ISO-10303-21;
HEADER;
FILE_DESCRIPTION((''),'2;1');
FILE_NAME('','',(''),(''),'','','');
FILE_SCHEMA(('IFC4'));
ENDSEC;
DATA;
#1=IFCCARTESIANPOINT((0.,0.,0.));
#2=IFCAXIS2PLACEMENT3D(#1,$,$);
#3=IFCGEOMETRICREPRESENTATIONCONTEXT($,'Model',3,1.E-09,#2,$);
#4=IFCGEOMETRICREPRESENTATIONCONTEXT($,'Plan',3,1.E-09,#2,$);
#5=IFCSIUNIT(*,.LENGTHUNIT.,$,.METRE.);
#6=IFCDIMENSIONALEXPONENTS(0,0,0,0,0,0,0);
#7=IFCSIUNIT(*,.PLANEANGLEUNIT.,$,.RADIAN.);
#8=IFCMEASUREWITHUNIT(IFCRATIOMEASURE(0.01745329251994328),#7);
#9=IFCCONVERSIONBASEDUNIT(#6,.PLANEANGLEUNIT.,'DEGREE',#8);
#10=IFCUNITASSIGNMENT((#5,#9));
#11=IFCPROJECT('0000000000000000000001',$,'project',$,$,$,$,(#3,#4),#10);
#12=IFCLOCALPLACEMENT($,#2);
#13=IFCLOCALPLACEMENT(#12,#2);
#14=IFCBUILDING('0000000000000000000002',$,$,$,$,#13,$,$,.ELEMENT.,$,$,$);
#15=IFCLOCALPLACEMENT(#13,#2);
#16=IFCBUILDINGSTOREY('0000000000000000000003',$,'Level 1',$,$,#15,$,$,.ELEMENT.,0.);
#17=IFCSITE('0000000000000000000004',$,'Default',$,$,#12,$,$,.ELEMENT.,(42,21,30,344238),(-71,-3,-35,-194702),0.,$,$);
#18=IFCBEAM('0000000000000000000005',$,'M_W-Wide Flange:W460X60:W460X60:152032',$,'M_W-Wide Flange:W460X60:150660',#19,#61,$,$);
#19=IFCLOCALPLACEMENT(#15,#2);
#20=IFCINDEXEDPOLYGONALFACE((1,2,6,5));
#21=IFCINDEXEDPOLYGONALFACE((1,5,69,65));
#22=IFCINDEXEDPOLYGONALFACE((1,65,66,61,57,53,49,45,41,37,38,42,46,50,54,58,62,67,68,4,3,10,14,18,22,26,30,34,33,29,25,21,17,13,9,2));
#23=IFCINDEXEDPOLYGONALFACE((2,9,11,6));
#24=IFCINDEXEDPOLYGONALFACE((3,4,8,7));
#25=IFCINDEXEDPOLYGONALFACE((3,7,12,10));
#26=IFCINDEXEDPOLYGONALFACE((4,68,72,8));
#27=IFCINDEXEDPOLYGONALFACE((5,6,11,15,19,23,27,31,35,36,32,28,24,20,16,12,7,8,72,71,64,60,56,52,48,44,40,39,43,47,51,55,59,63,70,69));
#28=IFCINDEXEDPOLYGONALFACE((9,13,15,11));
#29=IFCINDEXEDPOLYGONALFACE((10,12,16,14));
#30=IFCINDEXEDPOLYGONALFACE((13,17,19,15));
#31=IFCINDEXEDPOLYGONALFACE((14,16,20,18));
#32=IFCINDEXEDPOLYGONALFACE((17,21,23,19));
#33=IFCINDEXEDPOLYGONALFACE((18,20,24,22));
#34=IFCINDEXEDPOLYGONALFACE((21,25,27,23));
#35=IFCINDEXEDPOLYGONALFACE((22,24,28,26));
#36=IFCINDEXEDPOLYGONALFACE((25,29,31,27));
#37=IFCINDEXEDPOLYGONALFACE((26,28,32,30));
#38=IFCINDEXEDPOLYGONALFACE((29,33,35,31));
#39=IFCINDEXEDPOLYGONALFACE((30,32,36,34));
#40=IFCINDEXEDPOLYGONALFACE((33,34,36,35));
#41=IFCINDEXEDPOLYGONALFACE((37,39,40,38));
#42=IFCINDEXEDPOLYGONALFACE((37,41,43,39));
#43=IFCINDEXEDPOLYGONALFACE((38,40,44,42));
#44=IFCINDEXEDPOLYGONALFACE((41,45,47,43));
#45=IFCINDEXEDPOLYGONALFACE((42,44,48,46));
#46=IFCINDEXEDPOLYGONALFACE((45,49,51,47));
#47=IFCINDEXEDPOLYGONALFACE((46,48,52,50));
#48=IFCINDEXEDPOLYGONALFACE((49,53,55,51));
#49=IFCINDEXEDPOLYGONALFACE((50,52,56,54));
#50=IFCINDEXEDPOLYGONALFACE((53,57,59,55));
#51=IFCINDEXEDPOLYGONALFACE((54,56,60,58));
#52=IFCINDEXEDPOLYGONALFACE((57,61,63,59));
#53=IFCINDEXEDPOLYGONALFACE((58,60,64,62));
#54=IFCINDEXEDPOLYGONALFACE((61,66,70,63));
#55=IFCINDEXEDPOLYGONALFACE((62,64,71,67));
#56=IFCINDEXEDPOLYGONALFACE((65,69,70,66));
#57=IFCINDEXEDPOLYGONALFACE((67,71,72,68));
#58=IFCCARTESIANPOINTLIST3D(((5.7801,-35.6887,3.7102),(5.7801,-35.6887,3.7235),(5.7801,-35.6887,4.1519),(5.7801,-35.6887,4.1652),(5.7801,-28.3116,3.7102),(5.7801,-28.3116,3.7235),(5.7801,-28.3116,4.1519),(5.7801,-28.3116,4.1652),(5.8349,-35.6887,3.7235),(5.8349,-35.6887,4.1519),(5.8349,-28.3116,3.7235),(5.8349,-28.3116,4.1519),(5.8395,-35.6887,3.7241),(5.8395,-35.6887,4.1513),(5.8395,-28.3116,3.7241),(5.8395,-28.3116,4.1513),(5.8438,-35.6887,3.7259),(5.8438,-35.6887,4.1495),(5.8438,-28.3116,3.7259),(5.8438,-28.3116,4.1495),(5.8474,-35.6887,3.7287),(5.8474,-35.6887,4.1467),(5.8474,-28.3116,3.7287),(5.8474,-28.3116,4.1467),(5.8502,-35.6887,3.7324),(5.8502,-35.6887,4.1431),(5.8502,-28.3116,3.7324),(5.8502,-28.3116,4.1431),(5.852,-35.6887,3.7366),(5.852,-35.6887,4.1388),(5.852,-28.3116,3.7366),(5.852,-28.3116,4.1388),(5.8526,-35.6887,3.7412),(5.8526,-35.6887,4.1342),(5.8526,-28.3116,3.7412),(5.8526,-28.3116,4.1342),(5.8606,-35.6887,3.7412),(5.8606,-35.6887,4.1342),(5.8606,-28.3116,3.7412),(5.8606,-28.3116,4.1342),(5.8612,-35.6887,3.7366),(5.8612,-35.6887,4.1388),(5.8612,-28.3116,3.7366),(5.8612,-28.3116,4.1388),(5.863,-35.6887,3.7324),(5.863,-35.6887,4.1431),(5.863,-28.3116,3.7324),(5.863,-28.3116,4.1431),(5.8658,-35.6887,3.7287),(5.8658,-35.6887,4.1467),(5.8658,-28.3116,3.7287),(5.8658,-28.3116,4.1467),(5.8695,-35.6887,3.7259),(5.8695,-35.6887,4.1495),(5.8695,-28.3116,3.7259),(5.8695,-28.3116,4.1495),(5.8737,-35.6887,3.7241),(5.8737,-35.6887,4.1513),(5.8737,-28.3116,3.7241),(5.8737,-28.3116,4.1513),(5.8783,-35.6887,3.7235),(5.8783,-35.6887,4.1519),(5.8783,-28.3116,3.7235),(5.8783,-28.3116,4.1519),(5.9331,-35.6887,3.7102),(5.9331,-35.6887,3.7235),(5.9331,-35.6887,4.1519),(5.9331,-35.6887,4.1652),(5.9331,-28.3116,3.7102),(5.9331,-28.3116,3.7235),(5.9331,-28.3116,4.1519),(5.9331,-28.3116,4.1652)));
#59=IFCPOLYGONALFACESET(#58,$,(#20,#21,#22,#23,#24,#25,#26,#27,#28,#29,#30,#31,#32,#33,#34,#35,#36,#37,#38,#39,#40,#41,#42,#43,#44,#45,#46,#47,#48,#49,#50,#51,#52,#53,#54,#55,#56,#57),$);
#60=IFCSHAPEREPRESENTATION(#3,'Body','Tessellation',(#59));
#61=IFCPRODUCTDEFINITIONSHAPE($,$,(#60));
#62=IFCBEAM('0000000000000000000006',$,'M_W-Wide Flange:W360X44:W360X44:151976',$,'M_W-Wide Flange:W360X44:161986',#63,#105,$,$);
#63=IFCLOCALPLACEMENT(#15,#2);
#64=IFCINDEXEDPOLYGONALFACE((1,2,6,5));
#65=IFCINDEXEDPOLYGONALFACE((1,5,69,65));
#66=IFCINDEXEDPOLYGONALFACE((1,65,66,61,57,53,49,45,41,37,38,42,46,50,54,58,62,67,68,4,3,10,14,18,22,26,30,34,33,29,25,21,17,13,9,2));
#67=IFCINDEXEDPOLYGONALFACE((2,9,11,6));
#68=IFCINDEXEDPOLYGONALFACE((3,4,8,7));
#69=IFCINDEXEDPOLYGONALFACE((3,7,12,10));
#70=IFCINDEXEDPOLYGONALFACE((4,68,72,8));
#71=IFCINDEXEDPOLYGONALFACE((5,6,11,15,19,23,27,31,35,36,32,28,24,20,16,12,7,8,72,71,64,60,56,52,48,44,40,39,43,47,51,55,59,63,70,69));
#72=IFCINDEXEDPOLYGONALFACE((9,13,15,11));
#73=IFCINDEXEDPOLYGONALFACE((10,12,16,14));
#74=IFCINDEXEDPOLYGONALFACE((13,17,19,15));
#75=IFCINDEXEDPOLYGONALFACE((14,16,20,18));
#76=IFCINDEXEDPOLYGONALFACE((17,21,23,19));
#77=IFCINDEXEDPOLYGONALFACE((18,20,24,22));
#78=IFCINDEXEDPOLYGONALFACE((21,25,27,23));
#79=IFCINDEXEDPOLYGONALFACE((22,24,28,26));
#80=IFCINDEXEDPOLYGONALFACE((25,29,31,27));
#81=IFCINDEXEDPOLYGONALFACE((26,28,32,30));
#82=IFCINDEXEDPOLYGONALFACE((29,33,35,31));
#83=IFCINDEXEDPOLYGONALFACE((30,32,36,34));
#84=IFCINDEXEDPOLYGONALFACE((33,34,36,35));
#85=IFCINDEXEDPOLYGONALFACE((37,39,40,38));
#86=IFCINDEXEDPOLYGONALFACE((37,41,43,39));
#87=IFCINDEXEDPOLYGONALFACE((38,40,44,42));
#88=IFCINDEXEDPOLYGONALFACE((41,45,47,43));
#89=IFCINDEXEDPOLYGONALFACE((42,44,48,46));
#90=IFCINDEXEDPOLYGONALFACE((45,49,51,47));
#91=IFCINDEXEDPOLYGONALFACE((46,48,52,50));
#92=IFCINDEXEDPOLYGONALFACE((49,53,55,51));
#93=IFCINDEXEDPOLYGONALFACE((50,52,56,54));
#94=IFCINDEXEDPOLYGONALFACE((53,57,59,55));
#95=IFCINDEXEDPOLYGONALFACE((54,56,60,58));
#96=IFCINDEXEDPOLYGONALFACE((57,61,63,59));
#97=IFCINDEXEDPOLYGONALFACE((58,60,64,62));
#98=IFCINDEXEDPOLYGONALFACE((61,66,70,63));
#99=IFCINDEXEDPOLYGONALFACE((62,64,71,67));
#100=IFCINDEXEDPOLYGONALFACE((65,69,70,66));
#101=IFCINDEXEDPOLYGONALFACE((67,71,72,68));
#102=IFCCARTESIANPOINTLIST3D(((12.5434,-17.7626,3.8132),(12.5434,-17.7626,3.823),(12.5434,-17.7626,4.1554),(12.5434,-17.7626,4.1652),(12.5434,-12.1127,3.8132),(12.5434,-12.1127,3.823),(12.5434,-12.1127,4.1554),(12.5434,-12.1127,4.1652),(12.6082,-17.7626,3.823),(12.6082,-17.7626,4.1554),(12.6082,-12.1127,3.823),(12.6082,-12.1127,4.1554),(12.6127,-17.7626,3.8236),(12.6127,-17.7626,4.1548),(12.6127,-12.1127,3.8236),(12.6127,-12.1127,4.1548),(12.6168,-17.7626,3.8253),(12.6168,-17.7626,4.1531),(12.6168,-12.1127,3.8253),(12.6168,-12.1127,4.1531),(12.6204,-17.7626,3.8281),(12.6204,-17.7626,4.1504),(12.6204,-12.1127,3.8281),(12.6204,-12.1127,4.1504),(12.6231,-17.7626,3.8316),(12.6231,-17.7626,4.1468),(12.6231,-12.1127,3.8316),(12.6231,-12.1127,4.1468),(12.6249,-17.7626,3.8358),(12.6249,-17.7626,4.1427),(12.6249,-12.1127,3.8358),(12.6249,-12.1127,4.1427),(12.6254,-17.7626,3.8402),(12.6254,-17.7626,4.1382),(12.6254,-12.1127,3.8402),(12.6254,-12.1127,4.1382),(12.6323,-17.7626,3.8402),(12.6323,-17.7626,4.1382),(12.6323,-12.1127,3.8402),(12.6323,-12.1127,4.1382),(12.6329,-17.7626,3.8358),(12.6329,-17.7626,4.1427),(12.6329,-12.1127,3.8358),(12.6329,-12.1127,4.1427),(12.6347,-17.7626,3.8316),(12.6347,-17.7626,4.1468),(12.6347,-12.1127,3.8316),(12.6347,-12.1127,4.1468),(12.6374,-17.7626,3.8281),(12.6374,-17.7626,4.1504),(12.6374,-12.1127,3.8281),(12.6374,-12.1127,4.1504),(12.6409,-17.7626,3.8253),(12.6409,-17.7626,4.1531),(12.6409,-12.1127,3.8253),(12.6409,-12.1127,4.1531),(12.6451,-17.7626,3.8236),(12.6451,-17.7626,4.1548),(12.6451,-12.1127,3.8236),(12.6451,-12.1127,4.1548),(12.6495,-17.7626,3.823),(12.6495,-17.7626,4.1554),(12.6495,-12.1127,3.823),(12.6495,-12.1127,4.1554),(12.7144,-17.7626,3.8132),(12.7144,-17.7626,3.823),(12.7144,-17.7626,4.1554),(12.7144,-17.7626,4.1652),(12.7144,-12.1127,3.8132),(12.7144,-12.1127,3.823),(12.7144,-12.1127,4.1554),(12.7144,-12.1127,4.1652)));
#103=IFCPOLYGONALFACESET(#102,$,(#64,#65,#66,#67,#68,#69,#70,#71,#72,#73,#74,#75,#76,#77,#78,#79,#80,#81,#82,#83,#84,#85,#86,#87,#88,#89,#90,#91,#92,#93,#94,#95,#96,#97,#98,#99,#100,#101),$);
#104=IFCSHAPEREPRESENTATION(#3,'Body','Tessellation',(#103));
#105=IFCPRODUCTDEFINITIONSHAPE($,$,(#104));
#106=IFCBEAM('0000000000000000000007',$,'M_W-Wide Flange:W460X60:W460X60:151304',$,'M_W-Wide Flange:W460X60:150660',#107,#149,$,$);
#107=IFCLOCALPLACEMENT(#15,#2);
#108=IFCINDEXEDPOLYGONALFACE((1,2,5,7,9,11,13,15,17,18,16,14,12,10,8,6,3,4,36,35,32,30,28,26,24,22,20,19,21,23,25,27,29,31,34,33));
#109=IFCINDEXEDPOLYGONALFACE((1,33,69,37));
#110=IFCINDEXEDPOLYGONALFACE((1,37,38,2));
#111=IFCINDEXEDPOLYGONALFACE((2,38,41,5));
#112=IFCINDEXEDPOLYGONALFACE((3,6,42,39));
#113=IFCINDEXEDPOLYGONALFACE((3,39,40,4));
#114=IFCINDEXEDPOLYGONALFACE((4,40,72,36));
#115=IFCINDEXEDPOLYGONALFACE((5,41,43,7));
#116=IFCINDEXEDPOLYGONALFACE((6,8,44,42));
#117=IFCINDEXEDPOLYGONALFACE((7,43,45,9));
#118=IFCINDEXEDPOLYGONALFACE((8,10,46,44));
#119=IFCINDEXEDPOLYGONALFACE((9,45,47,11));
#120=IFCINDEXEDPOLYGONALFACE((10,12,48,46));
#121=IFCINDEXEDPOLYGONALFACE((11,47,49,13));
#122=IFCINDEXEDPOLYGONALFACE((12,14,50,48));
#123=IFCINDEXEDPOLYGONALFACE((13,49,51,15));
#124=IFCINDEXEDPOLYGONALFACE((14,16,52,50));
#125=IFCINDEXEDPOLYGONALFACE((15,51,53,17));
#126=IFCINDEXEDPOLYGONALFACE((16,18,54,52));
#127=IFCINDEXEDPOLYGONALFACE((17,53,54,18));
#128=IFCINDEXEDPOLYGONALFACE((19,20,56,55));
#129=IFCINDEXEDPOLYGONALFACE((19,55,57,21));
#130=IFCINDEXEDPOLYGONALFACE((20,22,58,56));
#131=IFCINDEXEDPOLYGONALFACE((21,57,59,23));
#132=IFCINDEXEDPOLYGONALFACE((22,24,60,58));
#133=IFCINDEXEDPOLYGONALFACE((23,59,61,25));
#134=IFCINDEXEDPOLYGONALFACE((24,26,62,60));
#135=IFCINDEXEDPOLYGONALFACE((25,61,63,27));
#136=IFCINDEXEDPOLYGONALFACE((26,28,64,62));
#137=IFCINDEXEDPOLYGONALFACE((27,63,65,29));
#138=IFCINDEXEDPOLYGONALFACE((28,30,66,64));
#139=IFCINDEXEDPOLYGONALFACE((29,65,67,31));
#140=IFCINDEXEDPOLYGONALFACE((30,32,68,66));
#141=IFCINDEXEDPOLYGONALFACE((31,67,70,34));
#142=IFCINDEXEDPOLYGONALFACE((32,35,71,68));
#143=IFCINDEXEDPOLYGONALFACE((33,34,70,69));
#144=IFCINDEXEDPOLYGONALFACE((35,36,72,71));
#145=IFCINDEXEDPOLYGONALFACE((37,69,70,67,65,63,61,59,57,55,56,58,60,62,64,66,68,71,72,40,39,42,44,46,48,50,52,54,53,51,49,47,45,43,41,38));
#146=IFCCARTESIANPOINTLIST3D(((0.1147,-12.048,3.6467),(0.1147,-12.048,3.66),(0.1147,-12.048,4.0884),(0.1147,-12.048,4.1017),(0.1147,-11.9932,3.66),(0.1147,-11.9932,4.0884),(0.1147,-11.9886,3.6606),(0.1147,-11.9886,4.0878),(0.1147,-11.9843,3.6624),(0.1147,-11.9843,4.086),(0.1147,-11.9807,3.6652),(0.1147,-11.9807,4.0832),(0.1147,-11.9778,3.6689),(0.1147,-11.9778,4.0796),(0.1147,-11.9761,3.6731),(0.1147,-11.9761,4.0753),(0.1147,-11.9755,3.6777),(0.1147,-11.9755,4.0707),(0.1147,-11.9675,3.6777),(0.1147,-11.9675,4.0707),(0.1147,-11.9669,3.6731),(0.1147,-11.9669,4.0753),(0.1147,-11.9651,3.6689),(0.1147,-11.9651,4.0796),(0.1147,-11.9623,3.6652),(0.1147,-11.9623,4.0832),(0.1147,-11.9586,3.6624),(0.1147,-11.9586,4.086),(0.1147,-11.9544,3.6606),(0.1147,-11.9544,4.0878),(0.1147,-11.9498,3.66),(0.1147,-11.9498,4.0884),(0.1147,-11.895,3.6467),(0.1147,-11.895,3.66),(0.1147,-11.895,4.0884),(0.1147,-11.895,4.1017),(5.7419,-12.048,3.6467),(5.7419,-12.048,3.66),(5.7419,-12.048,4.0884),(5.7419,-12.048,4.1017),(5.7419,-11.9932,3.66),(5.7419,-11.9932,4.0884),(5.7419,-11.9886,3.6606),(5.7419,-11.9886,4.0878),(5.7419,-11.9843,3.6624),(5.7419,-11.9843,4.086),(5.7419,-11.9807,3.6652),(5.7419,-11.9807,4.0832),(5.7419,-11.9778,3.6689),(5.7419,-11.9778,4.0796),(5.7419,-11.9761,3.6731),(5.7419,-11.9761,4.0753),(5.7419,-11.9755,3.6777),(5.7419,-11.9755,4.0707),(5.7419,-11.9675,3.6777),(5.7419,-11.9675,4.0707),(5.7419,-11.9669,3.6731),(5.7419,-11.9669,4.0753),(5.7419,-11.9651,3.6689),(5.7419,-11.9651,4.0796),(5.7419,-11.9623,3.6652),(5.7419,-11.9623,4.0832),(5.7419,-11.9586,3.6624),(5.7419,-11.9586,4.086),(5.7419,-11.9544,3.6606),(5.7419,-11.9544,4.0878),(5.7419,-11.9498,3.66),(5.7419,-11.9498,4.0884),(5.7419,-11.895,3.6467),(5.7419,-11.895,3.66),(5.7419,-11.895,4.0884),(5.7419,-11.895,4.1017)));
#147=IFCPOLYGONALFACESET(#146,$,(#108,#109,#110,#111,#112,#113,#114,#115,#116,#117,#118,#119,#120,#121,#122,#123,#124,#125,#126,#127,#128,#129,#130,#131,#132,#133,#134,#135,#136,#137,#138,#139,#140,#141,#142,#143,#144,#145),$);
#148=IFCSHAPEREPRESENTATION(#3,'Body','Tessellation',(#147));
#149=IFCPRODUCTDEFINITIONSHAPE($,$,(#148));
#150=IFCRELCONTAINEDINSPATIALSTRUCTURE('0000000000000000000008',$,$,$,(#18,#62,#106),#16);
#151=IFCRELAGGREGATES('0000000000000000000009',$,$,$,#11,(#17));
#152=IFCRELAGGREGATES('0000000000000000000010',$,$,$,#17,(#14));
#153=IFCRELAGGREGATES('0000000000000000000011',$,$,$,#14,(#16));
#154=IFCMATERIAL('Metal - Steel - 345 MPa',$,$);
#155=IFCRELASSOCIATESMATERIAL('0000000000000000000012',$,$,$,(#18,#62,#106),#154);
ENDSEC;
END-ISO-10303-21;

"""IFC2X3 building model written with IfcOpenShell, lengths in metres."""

from ifc_helpers import new_model, entity, si_unit, converted_unit, frame, frame_2d, origin, place, context, project, spatial, polyline, circle_curve, parameter, trimmed, segment, composite_curve, outline, extrude, material, element, save


model = new_model("IFC2X3")

# Units and contexts
model_context = context("Model", 3, precision=1e-09, world=origin())
plan_context = context("Plan", 3, precision=1e-09, world=origin())
ifc_project = project(units=[si_unit("LENGTHUNIT", "METRE"), converted_unit("PLANEANGLEUNIT", "DEGREE", entity("IfcRatioMeasure", 0.01745329251994328), si_unit("PLANEANGLEUNIT", "RADIAN"), dimensions=[0, 0, 0, 0, 0, 0, 0])], contexts=[model_context, plan_context])

# Site, building, storey
site_placement = place(None, origin())
site = spatial("IfcSite", under=ifc_project, at=site_placement, Name="Default", CompositionType="ELEMENT", RefLatitude=(42, 21, 30, 344238), RefLongitude=(-71, -3, -35, -194702), RefElevation=0.0)
building_placement = place(site_placement, origin())
building = spatial("IfcBuilding", under=site, at=building_placement, CompositionType="ELEMENT")
storey_placement = place(building_placement, origin())
storey = spatial("IfcBuildingStorey", under=building, at=storey_placement, Name="Level 1", CompositionType="ELEMENT", Elevation=0.0)

# Beams
ifc_material_1 = material(Name="Metal - Steel - 345 MPa")
beam_1_placement = place(storey_placement, frame((5.8566, -35.8299, 4.2672)))
element("IfcBeam", 1, at=beam_1_placement, inside=storey, material=ifc_material_1, Name="M_W-Wide Flange:W460X60:W460X60:152032", ObjectType="M_W-Wide Flange:W460X60:150660", context=model_context, shape_type="SweptSolid", body=[
    extrude(outline(composite_curve([segment(polyline([(-0.0765, -0.2142), (-0.0765, -0.2275)]), True, "CONTINUOUS"), segment(polyline([(-0.0765, -0.2275), (0.0765, -0.2275)]), True, "CONTINUOUS"), segment(polyline([(0.0765, -0.2275), (0.0765, -0.2142)]), True, "CONTINUOUS"), segment(polyline([(0.0765, -0.2142), (0.0217, -0.2142)]), True, "CONTINUOUS"), segment(trimmed(circle_curve(frame_2d((0.0217, -0.1965), x_axis=(0.0, -1.0)), 0.0177), [parameter(270.0)], [parameter(360.0)], True, "PARAMETER"), False, "CONTINUOUS"), segment(polyline([(0.004, -0.1965), (0.004, 0.1965)]), True, "CONTINUOUS"), segment(trimmed(circle_curve(frame_2d((0.0217, 0.1965), x_axis=(-1.0, 0.0)), 0.0177), [parameter(270.0)], [parameter(360.0)], True, "PARAMETER"), False, "CONTINUOUS"), segment(polyline([(0.0217, 0.2142), (0.0765, 0.2142)]), True, "CONTINUOUS"), segment(polyline([(0.0765, 0.2142), (0.0765, 0.2275)]), True, "CONTINUOUS"), segment(polyline([(0.0765, 0.2275), (-0.0765, 0.2275)]), True, "CONTINUOUS"), segment(polyline([(-0.0765, 0.2275), (-0.0765, 0.2142)]), True, "CONTINUOUS"), segment(polyline([(-0.0765, 0.2142), (-0.0217, 0.2142)]), True, "CONTINUOUS"), segment(trimmed(circle_curve(frame_2d((-0.0217, 0.1965), x_axis=(0.0, 1.0)), 0.0177), [parameter(270.0)], [parameter(360.0)], True, "PARAMETER"), False, "CONTINUOUS"), segment(polyline([(-0.004, 0.1965), (-0.004, -0.1965)]), True, "CONTINUOUS"), segment(trimmed(circle_curve(frame_2d((-0.0217, -0.1965), x_axis=(1.0, 0.0)), 0.0177), [parameter(270.0)], [parameter(0.0)], True, "PARAMETER"), False, "CONTINUOUS"), segment(polyline([(-0.0217, -0.2142), (-0.0765, -0.2142)]), True, "CONTINUOUS")], self_intersect=False)), frame((0.0, 0.1412, -0.3295), z_axis=(0.0, -1.0, 0.0), x_axis=(1.0, 0.0, 0.0)), (0.0, 0.0, -1.0), 7.3771),
])
beam_2_placement = place(storey_placement, frame((12.6289, -11.9715, 4.2672), z_axis=(0.0, 0.0, 1.0), x_axis=(-1.0, 0.0, 0.0)))
element("IfcBeam", 2, at=beam_2_placement, inside=storey, material=ifc_material_1, Name="M_W-Wide Flange:W360X44:W360X44:151976", ObjectType="M_W-Wide Flange:W360X44:161986", context=model_context, shape_type="SweptSolid", body=[
    extrude(outline(composite_curve([segment(polyline([(0.1662, -0.0855), (0.176, -0.0855)]), True, "CONTINUOUS"), segment(polyline([(0.176, -0.0855), (0.176, 0.0855)]), True, "CONTINUOUS"), segment(polyline([(0.176, 0.0855), (0.1662, 0.0855)]), True, "CONTINUOUS"), segment(polyline([(0.1662, 0.0855), (0.1662, 0.0207)]), True, "CONTINUOUS"), segment(trimmed(circle_curve(frame_2d((0.149, 0.0207), x_axis=(0.0, 1.0)), 0.0172), [parameter(180.0)], [parameter(270.0)], True, "PARAMETER"), False, "CONTINUOUS"), segment(polyline([(0.149, 0.0035), (-0.149, 0.0035)]), True, "CONTINUOUS"), segment(trimmed(circle_curve(frame_2d((-0.149, 0.0207), x_axis=(0.0, 1.0)), 0.0172), [parameter(90.0)], [parameter(180.0)], True, "PARAMETER"), False, "CONTINUOUS"), segment(polyline([(-0.1662, 0.0207), (-0.1662, 0.0855)]), True, "CONTINUOUS"), segment(polyline([(-0.1662, 0.0855), (-0.176, 0.0855)]), True, "CONTINUOUS"), segment(polyline([(-0.176, 0.0855), (-0.176, -0.0855)]), True, "CONTINUOUS"), segment(polyline([(-0.176, -0.0855), (-0.1662, -0.0855)]), True, "CONTINUOUS"), segment(polyline([(-0.1662, -0.0855), (-0.1662, -0.0206)]), True, "CONTINUOUS"), segment(trimmed(circle_curve(frame_2d((-0.149, -0.0206), x_axis=(0.0, 1.0)), 0.0172), [parameter(360.0)], [parameter(90.0)], True, "PARAMETER"), False, "CONTINUOUS"), segment(polyline([(-0.149, -0.0034), (0.149, -0.0034)]), True, "CONTINUOUS"), segment(trimmed(circle_curve(frame_2d((0.149, -0.0206), x_axis=(0.0, 1.0)), 0.0172), [parameter(270.0)], [parameter(0.0)], True, "PARAMETER"), False, "CONTINUOUS"), segment(polyline([(0.1662, -0.0206), (0.1662, -0.0855)]), True, "CONTINUOUS")], self_intersect=False)), frame((0.0, 5.7912, -0.278), z_axis=(0.0, -1.0, 0.0), x_axis=(0.0, 0.0, -1.0)), (0.0, 0.0, 1.0), 5.65),
])
beam_3_placement = place(storey_placement, frame((0.0, -11.9715, 4.2672), z_axis=(0.0, 0.0, 1.0), x_axis=(0.0, -1.0, 0.0)))
element("IfcBeam", 3, at=beam_3_placement, inside=storey, material=ifc_material_1, Name="M_W-Wide Flange:W460X60:W460X60:151304", ObjectType="M_W-Wide Flange:W460X60:150660", context=model_context, shape_type="SweptSolid", body=[
    extrude(outline(composite_curve([segment(polyline([(-0.0765, -0.2142), (-0.0765, -0.2275)]), True, "CONTINUOUS"), segment(polyline([(-0.0765, -0.2275), (0.0765, -0.2275)]), True, "CONTINUOUS"), segment(polyline([(0.0765, -0.2275), (0.0765, -0.2142)]), True, "CONTINUOUS"), segment(polyline([(0.0765, -0.2142), (0.0217, -0.2142)]), True, "CONTINUOUS"), segment(trimmed(circle_curve(frame_2d((0.0217, -0.1965), x_axis=(0.0, -1.0)), 0.0177), [parameter(270.0)], [parameter(360.0)], True, "PARAMETER"), False, "CONTINUOUS"), segment(polyline([(0.004, -0.1965), (0.004, 0.1965)]), True, "CONTINUOUS"), segment(trimmed(circle_curve(frame_2d((0.0217, 0.1965), x_axis=(-1.0, 0.0)), 0.0177), [parameter(270.0)], [parameter(360.0)], True, "PARAMETER"), False, "CONTINUOUS"), segment(polyline([(0.0217, 0.2142), (0.0765, 0.2142)]), True, "CONTINUOUS"), segment(polyline([(0.0765, 0.2142), (0.0765, 0.2275)]), True, "CONTINUOUS"), segment(polyline([(0.0765, 0.2275), (-0.0765, 0.2275)]), True, "CONTINUOUS"), segment(polyline([(-0.0765, 0.2275), (-0.0765, 0.2142)]), True, "CONTINUOUS"), segment(polyline([(-0.0765, 0.2142), (-0.0217, 0.2142)]), True, "CONTINUOUS"), segment(trimmed(circle_curve(frame_2d((-0.0217, 0.1965), x_axis=(0.0, 1.0)), 0.0177), [parameter(270.0)], [parameter(360.0)], True, "PARAMETER"), False, "CONTINUOUS"), segment(polyline([(-0.004, 0.1965), (-0.004, -0.1965)]), True, "CONTINUOUS"), segment(trimmed(circle_curve(frame_2d((-0.0217, -0.1965), x_axis=(1.0, 0.0)), 0.0177), [parameter(270.0)], [parameter(0.0)], True, "PARAMETER"), False, "CONTINUOUS"), segment(polyline([(-0.0217, -0.2142), (-0.0765, -0.2142)]), True, "CONTINUOUS")], self_intersect=False)), frame((0.0, 0.1147, -0.393), z_axis=(0.0, -1.0, 0.0), x_axis=(1.0, 0.0, 0.0)), (0.0, 0.0, -1.0), 5.6272),
])

save(model, "model.ifc")
